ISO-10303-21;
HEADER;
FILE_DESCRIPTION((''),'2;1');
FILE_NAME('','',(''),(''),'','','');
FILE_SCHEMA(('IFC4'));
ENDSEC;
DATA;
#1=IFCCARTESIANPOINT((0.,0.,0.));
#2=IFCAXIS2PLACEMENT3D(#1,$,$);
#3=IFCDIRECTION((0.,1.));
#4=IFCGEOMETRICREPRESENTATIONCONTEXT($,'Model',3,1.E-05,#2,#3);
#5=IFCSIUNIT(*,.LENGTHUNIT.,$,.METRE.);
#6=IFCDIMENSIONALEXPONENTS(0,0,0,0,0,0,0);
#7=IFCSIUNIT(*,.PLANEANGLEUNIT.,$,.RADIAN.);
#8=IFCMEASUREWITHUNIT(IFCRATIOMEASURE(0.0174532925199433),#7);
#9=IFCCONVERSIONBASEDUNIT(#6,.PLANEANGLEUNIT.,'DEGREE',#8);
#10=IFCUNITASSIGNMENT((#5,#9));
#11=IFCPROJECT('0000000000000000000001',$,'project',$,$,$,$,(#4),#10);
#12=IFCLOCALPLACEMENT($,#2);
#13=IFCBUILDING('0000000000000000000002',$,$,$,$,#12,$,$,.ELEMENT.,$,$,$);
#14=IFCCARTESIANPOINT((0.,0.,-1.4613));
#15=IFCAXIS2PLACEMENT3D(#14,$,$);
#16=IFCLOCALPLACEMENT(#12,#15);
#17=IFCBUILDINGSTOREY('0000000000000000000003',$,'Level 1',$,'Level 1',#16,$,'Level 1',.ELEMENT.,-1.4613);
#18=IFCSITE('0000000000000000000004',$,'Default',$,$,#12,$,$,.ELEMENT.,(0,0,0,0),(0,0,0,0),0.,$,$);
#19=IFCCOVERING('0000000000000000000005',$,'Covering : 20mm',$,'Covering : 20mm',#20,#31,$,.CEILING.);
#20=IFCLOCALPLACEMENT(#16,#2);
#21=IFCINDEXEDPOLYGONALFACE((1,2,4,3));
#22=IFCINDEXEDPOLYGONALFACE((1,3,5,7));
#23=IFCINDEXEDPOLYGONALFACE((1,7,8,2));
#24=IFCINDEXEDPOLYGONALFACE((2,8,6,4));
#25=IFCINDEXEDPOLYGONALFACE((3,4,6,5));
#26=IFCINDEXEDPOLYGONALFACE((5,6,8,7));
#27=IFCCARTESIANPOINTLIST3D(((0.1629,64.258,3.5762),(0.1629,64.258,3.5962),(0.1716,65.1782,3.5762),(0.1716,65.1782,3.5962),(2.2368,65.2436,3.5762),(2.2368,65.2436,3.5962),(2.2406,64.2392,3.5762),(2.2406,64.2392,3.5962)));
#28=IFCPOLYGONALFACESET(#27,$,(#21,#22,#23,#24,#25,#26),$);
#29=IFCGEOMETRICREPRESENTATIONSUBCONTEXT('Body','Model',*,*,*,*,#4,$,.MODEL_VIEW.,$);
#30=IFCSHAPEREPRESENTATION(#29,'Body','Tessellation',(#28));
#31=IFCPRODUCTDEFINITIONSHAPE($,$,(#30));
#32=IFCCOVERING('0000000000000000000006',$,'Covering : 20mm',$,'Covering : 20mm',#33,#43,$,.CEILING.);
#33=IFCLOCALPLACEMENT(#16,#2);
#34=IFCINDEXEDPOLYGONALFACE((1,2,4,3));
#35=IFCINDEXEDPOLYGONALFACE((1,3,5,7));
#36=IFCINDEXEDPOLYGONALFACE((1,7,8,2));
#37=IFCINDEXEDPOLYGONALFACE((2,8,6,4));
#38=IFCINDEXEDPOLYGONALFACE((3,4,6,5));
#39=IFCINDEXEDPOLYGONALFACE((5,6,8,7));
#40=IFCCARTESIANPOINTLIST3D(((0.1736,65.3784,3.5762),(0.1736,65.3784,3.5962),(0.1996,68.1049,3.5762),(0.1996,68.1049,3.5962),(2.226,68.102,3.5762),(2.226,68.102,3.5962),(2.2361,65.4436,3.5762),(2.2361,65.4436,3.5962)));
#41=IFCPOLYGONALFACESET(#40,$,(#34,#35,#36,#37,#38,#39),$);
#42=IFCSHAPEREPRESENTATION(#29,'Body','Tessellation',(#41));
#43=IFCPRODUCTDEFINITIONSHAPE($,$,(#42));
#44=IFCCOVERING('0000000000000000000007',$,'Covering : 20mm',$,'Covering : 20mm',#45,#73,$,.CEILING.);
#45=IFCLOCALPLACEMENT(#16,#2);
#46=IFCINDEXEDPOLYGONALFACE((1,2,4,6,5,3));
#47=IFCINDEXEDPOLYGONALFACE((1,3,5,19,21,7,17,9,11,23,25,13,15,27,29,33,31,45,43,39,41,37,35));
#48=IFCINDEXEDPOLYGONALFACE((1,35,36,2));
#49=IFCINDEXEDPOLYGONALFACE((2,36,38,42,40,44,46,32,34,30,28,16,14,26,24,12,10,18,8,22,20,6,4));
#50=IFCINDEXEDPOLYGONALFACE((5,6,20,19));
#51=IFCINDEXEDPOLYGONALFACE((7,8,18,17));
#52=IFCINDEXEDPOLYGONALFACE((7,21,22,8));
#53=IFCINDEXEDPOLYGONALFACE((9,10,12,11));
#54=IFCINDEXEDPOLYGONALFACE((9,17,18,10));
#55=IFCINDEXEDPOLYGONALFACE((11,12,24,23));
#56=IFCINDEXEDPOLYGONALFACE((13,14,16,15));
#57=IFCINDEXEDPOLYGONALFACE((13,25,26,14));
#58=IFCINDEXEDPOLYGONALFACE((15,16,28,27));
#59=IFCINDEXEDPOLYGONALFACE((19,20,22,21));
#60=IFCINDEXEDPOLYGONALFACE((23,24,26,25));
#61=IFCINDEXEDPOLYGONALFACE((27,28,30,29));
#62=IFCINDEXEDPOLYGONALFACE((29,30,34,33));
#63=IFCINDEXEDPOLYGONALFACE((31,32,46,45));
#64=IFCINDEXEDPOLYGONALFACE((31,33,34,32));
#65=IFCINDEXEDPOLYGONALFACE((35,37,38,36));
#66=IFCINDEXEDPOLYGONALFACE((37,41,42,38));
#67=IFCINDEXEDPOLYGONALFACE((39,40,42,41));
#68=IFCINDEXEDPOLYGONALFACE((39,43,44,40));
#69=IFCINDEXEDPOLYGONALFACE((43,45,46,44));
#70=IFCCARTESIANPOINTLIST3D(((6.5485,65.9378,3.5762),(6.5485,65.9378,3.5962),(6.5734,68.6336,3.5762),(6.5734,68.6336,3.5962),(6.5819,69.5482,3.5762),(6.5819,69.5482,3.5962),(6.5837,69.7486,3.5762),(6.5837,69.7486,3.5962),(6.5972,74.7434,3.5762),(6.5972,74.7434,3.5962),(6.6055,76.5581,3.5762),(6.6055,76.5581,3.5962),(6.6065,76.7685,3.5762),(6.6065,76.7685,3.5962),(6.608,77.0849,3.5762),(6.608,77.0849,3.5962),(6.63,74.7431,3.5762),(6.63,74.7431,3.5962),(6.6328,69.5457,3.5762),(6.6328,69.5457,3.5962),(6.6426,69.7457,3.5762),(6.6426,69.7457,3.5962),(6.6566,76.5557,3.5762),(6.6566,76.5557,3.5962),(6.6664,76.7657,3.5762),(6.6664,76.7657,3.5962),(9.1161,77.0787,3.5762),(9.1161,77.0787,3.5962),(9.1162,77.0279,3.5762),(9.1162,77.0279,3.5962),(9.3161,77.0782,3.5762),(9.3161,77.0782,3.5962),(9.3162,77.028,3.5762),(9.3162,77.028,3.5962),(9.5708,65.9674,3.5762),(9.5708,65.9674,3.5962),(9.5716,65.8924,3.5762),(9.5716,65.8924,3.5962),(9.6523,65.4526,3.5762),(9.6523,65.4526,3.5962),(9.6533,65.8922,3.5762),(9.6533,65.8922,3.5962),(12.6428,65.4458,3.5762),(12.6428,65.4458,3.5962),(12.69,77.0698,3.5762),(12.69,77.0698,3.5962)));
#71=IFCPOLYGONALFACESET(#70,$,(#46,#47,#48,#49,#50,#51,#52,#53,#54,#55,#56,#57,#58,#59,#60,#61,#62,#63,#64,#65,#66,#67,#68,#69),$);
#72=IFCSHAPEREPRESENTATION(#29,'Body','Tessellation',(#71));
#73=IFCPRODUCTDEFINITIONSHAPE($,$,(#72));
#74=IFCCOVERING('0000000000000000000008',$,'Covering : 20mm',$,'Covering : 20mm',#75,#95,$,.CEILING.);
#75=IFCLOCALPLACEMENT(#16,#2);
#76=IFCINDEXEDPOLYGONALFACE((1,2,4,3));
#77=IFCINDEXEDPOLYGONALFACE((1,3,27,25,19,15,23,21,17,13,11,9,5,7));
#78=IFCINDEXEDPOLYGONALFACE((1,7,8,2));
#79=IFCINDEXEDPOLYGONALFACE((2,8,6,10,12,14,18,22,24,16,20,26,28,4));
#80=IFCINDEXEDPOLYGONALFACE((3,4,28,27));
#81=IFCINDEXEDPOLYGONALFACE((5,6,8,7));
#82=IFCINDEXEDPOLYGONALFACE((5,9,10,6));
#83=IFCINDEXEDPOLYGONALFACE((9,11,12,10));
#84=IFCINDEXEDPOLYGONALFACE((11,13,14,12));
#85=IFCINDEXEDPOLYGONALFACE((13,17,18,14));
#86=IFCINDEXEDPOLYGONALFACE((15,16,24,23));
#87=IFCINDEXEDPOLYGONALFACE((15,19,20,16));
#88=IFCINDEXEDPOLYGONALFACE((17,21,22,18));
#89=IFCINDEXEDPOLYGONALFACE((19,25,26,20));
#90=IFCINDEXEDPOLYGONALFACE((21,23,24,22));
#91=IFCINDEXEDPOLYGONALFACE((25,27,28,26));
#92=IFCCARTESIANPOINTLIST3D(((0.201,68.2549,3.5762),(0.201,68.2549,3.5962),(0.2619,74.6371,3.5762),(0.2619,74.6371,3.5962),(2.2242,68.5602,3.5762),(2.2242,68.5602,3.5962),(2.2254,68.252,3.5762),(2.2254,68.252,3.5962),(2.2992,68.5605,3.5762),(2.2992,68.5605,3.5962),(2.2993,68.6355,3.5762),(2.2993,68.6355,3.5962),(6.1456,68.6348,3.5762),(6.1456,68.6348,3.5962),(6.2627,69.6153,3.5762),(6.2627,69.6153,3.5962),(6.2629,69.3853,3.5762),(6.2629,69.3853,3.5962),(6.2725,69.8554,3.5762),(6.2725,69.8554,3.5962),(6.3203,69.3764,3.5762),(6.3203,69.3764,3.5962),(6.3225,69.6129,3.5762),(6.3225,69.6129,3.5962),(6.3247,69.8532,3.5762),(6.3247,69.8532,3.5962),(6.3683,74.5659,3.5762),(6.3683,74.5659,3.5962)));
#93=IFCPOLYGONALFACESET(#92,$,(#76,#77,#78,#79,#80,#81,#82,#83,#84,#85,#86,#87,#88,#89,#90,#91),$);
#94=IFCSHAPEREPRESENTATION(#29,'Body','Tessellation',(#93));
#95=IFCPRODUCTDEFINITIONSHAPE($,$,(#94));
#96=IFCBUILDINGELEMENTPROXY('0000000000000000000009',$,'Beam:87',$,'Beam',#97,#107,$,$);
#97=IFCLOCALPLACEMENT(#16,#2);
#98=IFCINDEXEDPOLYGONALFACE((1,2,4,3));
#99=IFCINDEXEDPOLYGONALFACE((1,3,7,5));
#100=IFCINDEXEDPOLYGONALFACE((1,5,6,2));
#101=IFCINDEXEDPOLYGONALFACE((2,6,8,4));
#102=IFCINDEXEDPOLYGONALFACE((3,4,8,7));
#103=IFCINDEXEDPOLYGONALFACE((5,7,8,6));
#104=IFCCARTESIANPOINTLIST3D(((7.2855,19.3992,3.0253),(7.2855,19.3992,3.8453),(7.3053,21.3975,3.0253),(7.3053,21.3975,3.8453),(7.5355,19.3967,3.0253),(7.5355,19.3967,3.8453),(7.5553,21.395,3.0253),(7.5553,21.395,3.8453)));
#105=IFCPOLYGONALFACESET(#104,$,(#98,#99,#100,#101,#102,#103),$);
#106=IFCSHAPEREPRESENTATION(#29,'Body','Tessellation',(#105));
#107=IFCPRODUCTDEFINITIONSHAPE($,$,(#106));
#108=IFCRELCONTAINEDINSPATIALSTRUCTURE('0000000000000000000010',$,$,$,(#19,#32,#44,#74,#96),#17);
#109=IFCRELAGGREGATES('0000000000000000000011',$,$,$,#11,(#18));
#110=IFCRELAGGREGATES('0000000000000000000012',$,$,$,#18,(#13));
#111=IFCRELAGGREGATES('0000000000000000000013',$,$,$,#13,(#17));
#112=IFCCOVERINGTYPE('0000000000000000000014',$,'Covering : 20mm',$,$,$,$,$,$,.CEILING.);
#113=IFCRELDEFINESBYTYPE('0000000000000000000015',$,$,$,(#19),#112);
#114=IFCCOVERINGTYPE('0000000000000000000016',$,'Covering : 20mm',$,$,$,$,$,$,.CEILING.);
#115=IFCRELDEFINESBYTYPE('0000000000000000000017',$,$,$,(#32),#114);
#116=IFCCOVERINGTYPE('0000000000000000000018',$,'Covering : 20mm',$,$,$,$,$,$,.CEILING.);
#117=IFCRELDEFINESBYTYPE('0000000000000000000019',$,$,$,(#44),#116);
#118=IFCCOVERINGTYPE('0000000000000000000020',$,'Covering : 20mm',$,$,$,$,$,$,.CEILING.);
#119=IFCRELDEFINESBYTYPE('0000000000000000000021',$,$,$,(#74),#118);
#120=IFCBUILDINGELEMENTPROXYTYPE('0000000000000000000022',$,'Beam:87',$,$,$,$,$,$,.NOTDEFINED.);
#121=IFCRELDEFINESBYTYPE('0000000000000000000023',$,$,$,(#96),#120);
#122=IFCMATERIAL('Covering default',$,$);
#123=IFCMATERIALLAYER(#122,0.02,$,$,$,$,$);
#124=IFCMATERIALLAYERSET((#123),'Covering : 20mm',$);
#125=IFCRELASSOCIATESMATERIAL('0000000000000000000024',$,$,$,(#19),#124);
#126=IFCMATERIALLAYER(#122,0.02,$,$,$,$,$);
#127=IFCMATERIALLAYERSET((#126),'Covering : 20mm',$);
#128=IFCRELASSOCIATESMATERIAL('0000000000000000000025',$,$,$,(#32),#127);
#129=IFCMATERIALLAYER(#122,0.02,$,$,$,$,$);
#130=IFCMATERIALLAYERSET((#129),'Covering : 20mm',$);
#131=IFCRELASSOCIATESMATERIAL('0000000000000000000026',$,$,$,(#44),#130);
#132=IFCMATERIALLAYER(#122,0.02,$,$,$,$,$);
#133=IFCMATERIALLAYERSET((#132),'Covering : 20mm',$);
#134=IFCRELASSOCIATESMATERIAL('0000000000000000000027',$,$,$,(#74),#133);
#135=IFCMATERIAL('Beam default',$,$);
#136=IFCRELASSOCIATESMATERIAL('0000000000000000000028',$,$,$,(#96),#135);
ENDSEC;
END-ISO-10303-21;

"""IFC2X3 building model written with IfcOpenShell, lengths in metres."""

from ifc_helpers import new_model, entity, si_unit, converted_unit, direction, frame, origin, origin_with_axes, place, context, subcontext, project, spatial, polyline, outline, extrude, source, transform, mapped, material, layer, layer_set, layer_usage, type_object, type_shapes, element, save


model = new_model("IFC2X3")

# Units and contexts
model_context = context("Model", 3, precision=1e-05, world=origin(), true_north=direction((0.0, 1.0)))
body_context = subcontext(model_context, "Body", "Model", "MODEL_VIEW")
ifc_project = project(units=[si_unit("LENGTHUNIT", "METRE"), converted_unit("PLANEANGLEUNIT", "DEGREE", entity("IfcRatioMeasure", 0.0174532925199433), si_unit("PLANEANGLEUNIT", "RADIAN"), dimensions=[0, 0, 0, 0, 0, 0, 0])], contexts=[model_context])

# Site, building, storey
placement_1 = place(None, origin())
site = spatial("IfcSite", under=ifc_project, at=placement_1, Name="Default", CompositionType="ELEMENT", RefLatitude=(0, 0, 0, 0), RefLongitude=(0, 0, 0, 0), RefElevation=0.0)
building = spatial("IfcBuilding", under=site, at=placement_1, CompositionType="ELEMENT")
storey_placement = place(placement_1, frame((0.0, 0.0, -1.4613)))
storey = spatial("IfcBuildingStorey", under=building, at=storey_placement, Name="Level 1", ObjectType="Level 1", LongName="Level 1", CompositionType="ELEMENT", Elevation=-1.4613)

# Coverings
ifc_material_1 = material(Name="Covering default")
ifc_layer_1 = layer(ifc_material_1, 0.02)
ifc_layer_set_1 = layer_set([ifc_layer_1], Name="Covering : 20mm")
ifc_layer_usage_1 = layer_usage(ifc_layer_set_1, "AXIS3", "POSITIVE", 0.0)
covering_type_1 = type_object("IfcCoveringType", Name="Covering : 20mm", PredefinedType="CEILING")
covering_1_placement = place(placement_1, frame((0.0, 0.0, 2.1149)))
element("IfcCovering", 1, at=covering_1_placement, inside=storey, type_object=covering_type_1, material=ifc_layer_usage_1, Name="Covering : 20mm", ObjectType="Covering : 20mm", PredefinedType="CEILING", context=body_context, shape_type="SweptSolid", body=[
    extrude(outline(polyline([(0.1716, 65.1782), (2.2368, 65.2436), (2.2406, 64.2392), (0.1629, 64.258), (0.1716, 65.1782)])), origin_with_axes(), (0.0, 0.0, 1.0), 0.02),
])
ifc_layer_2 = layer(ifc_material_1, 0.02)
ifc_layer_set_2 = layer_set([ifc_layer_2], Name="Covering : 20mm")
ifc_layer_usage_2 = layer_usage(ifc_layer_set_2, "AXIS3", "POSITIVE", 0.0)
covering_type_2 = type_object("IfcCoveringType", Name="Covering : 20mm", PredefinedType="CEILING")
covering_2_placement = place(placement_1, frame((0.0, 0.0, 2.1149)))
element("IfcCovering", 2, at=covering_2_placement, inside=storey, type_object=covering_type_2, material=ifc_layer_usage_2, Name="Covering : 20mm", ObjectType="Covering : 20mm", PredefinedType="CEILING", context=body_context, shape_type="SweptSolid", body=[
    extrude(outline(polyline([(0.1996, 68.1049), (2.226, 68.102), (2.2361, 65.4436), (0.1736, 65.3784), (0.1996, 68.1049)])), origin_with_axes(), (0.0, 0.0, 1.0), 0.02),
])
ifc_layer_3 = layer(ifc_material_1, 0.02)
ifc_layer_set_3 = layer_set([ifc_layer_3], Name="Covering : 20mm")
ifc_layer_usage_3 = layer_usage(ifc_layer_set_3, "AXIS3", "POSITIVE", 0.0)
covering_type_3 = type_object("IfcCoveringType", Name="Covering : 20mm", PredefinedType="CEILING")
covering_3_placement = place(placement_1, frame((0.0, 0.0, 2.1149)))
element("IfcCovering", 3, at=covering_3_placement, inside=storey, type_object=covering_type_3, material=ifc_layer_usage_3, Name="Covering : 20mm", ObjectType="Covering : 20mm", PredefinedType="CEILING", context=body_context, shape_type="SweptSolid", body=[
    extrude(outline(polyline([(6.5734, 68.6336), (6.5734, 68.6336), (6.5819, 69.5482), (6.6328, 69.5457), (6.6426, 69.7457), (6.5837, 69.7486), (6.63, 74.7431), (6.5972, 74.7434), (6.6055, 76.5581), (6.6566, 76.5557), (6.6664, 76.7657), (6.6065, 76.7685), (6.608, 77.0849), (9.1161, 77.0787), (9.1162, 77.0279), (9.3162, 77.028), (9.3161, 77.0782), (12.69, 77.0698), (12.6428, 65.4458), (9.6523, 65.4526), (9.6533, 65.8922), (9.5716, 65.8924), (9.5708, 65.9674), (6.5485, 65.9378), (6.5734, 68.6336)])), origin_with_axes(), (0.0, 0.0, 1.0), 0.02),
])
ifc_layer_4 = layer(ifc_material_1, 0.02)
ifc_layer_set_4 = layer_set([ifc_layer_4], Name="Covering : 20mm")
ifc_layer_usage_4 = layer_usage(ifc_layer_set_4, "AXIS3", "POSITIVE", 0.0)
covering_type_4 = type_object("IfcCoveringType", Name="Covering : 20mm", PredefinedType="CEILING")
covering_4_placement = place(placement_1, frame((0.0, 0.0, 2.1149)))
element("IfcCovering", 4, at=covering_4_placement, inside=storey, type_object=covering_type_4, material=ifc_layer_usage_4, Name="Covering : 20mm", ObjectType="Covering : 20mm", PredefinedType="CEILING", context=body_context, shape_type="SweptSolid", body=[
    extrude(outline(polyline([(0.2619, 74.6371), (6.3683, 74.5659), (6.3247, 69.8532), (6.2725, 69.8554), (6.2627, 69.6153), (6.3225, 69.6129), (6.3203, 69.3764), (6.2629, 69.3853), (6.1456, 68.6348), (2.2993, 68.6355), (2.2992, 68.5605), (2.2242, 68.5602), (2.2254, 68.252), (0.201, 68.2549), (0.2619, 74.6371)])), origin_with_axes(), (0.0, 0.0, 1.0), 0.02),
])

# Building element proxy
ifc_material_2 = material(Name="Beam default")
building_element_proxy_type = type_object("IfcBuildingElementProxyType", Name="Beam:87", PredefinedType="NOTDEFINED")
shared_shape_1 = source(origin(), body_context, "Body", "SweptSolid", [
    extrude(outline(polyline([(1.9984, -0.125), (1.9984, 0.125), (0.0, 0.125), (0.0, -0.125), (1.9984, -0.125)])), origin(), (0.0, 0.0, 1.0), 0.82),
])
type_shapes(building_element_proxy_type, [shared_shape_1])
placement_2 = place(placement_1, frame((0.0, 0.0, 1.564)))
proxy_placement = place(placement_2, frame((7.4303, 21.3963, 0.0), z_axis=(0.0, 0.0, 1.0), x_axis=(-0.009922, -0.999951, 0.0)))
element("IfcBuildingElementProxy", 5, at=proxy_placement, inside=storey, type_object=building_element_proxy_type, material=ifc_material_2, Name="Beam:87", ObjectType="Beam", context=body_context, shape_type="MappedRepresentation", body=[
    mapped(shared_shape_1, transform((0.0, 0.0, 0.0), scale=1.0)),
])

save(model, "model.ifc")
